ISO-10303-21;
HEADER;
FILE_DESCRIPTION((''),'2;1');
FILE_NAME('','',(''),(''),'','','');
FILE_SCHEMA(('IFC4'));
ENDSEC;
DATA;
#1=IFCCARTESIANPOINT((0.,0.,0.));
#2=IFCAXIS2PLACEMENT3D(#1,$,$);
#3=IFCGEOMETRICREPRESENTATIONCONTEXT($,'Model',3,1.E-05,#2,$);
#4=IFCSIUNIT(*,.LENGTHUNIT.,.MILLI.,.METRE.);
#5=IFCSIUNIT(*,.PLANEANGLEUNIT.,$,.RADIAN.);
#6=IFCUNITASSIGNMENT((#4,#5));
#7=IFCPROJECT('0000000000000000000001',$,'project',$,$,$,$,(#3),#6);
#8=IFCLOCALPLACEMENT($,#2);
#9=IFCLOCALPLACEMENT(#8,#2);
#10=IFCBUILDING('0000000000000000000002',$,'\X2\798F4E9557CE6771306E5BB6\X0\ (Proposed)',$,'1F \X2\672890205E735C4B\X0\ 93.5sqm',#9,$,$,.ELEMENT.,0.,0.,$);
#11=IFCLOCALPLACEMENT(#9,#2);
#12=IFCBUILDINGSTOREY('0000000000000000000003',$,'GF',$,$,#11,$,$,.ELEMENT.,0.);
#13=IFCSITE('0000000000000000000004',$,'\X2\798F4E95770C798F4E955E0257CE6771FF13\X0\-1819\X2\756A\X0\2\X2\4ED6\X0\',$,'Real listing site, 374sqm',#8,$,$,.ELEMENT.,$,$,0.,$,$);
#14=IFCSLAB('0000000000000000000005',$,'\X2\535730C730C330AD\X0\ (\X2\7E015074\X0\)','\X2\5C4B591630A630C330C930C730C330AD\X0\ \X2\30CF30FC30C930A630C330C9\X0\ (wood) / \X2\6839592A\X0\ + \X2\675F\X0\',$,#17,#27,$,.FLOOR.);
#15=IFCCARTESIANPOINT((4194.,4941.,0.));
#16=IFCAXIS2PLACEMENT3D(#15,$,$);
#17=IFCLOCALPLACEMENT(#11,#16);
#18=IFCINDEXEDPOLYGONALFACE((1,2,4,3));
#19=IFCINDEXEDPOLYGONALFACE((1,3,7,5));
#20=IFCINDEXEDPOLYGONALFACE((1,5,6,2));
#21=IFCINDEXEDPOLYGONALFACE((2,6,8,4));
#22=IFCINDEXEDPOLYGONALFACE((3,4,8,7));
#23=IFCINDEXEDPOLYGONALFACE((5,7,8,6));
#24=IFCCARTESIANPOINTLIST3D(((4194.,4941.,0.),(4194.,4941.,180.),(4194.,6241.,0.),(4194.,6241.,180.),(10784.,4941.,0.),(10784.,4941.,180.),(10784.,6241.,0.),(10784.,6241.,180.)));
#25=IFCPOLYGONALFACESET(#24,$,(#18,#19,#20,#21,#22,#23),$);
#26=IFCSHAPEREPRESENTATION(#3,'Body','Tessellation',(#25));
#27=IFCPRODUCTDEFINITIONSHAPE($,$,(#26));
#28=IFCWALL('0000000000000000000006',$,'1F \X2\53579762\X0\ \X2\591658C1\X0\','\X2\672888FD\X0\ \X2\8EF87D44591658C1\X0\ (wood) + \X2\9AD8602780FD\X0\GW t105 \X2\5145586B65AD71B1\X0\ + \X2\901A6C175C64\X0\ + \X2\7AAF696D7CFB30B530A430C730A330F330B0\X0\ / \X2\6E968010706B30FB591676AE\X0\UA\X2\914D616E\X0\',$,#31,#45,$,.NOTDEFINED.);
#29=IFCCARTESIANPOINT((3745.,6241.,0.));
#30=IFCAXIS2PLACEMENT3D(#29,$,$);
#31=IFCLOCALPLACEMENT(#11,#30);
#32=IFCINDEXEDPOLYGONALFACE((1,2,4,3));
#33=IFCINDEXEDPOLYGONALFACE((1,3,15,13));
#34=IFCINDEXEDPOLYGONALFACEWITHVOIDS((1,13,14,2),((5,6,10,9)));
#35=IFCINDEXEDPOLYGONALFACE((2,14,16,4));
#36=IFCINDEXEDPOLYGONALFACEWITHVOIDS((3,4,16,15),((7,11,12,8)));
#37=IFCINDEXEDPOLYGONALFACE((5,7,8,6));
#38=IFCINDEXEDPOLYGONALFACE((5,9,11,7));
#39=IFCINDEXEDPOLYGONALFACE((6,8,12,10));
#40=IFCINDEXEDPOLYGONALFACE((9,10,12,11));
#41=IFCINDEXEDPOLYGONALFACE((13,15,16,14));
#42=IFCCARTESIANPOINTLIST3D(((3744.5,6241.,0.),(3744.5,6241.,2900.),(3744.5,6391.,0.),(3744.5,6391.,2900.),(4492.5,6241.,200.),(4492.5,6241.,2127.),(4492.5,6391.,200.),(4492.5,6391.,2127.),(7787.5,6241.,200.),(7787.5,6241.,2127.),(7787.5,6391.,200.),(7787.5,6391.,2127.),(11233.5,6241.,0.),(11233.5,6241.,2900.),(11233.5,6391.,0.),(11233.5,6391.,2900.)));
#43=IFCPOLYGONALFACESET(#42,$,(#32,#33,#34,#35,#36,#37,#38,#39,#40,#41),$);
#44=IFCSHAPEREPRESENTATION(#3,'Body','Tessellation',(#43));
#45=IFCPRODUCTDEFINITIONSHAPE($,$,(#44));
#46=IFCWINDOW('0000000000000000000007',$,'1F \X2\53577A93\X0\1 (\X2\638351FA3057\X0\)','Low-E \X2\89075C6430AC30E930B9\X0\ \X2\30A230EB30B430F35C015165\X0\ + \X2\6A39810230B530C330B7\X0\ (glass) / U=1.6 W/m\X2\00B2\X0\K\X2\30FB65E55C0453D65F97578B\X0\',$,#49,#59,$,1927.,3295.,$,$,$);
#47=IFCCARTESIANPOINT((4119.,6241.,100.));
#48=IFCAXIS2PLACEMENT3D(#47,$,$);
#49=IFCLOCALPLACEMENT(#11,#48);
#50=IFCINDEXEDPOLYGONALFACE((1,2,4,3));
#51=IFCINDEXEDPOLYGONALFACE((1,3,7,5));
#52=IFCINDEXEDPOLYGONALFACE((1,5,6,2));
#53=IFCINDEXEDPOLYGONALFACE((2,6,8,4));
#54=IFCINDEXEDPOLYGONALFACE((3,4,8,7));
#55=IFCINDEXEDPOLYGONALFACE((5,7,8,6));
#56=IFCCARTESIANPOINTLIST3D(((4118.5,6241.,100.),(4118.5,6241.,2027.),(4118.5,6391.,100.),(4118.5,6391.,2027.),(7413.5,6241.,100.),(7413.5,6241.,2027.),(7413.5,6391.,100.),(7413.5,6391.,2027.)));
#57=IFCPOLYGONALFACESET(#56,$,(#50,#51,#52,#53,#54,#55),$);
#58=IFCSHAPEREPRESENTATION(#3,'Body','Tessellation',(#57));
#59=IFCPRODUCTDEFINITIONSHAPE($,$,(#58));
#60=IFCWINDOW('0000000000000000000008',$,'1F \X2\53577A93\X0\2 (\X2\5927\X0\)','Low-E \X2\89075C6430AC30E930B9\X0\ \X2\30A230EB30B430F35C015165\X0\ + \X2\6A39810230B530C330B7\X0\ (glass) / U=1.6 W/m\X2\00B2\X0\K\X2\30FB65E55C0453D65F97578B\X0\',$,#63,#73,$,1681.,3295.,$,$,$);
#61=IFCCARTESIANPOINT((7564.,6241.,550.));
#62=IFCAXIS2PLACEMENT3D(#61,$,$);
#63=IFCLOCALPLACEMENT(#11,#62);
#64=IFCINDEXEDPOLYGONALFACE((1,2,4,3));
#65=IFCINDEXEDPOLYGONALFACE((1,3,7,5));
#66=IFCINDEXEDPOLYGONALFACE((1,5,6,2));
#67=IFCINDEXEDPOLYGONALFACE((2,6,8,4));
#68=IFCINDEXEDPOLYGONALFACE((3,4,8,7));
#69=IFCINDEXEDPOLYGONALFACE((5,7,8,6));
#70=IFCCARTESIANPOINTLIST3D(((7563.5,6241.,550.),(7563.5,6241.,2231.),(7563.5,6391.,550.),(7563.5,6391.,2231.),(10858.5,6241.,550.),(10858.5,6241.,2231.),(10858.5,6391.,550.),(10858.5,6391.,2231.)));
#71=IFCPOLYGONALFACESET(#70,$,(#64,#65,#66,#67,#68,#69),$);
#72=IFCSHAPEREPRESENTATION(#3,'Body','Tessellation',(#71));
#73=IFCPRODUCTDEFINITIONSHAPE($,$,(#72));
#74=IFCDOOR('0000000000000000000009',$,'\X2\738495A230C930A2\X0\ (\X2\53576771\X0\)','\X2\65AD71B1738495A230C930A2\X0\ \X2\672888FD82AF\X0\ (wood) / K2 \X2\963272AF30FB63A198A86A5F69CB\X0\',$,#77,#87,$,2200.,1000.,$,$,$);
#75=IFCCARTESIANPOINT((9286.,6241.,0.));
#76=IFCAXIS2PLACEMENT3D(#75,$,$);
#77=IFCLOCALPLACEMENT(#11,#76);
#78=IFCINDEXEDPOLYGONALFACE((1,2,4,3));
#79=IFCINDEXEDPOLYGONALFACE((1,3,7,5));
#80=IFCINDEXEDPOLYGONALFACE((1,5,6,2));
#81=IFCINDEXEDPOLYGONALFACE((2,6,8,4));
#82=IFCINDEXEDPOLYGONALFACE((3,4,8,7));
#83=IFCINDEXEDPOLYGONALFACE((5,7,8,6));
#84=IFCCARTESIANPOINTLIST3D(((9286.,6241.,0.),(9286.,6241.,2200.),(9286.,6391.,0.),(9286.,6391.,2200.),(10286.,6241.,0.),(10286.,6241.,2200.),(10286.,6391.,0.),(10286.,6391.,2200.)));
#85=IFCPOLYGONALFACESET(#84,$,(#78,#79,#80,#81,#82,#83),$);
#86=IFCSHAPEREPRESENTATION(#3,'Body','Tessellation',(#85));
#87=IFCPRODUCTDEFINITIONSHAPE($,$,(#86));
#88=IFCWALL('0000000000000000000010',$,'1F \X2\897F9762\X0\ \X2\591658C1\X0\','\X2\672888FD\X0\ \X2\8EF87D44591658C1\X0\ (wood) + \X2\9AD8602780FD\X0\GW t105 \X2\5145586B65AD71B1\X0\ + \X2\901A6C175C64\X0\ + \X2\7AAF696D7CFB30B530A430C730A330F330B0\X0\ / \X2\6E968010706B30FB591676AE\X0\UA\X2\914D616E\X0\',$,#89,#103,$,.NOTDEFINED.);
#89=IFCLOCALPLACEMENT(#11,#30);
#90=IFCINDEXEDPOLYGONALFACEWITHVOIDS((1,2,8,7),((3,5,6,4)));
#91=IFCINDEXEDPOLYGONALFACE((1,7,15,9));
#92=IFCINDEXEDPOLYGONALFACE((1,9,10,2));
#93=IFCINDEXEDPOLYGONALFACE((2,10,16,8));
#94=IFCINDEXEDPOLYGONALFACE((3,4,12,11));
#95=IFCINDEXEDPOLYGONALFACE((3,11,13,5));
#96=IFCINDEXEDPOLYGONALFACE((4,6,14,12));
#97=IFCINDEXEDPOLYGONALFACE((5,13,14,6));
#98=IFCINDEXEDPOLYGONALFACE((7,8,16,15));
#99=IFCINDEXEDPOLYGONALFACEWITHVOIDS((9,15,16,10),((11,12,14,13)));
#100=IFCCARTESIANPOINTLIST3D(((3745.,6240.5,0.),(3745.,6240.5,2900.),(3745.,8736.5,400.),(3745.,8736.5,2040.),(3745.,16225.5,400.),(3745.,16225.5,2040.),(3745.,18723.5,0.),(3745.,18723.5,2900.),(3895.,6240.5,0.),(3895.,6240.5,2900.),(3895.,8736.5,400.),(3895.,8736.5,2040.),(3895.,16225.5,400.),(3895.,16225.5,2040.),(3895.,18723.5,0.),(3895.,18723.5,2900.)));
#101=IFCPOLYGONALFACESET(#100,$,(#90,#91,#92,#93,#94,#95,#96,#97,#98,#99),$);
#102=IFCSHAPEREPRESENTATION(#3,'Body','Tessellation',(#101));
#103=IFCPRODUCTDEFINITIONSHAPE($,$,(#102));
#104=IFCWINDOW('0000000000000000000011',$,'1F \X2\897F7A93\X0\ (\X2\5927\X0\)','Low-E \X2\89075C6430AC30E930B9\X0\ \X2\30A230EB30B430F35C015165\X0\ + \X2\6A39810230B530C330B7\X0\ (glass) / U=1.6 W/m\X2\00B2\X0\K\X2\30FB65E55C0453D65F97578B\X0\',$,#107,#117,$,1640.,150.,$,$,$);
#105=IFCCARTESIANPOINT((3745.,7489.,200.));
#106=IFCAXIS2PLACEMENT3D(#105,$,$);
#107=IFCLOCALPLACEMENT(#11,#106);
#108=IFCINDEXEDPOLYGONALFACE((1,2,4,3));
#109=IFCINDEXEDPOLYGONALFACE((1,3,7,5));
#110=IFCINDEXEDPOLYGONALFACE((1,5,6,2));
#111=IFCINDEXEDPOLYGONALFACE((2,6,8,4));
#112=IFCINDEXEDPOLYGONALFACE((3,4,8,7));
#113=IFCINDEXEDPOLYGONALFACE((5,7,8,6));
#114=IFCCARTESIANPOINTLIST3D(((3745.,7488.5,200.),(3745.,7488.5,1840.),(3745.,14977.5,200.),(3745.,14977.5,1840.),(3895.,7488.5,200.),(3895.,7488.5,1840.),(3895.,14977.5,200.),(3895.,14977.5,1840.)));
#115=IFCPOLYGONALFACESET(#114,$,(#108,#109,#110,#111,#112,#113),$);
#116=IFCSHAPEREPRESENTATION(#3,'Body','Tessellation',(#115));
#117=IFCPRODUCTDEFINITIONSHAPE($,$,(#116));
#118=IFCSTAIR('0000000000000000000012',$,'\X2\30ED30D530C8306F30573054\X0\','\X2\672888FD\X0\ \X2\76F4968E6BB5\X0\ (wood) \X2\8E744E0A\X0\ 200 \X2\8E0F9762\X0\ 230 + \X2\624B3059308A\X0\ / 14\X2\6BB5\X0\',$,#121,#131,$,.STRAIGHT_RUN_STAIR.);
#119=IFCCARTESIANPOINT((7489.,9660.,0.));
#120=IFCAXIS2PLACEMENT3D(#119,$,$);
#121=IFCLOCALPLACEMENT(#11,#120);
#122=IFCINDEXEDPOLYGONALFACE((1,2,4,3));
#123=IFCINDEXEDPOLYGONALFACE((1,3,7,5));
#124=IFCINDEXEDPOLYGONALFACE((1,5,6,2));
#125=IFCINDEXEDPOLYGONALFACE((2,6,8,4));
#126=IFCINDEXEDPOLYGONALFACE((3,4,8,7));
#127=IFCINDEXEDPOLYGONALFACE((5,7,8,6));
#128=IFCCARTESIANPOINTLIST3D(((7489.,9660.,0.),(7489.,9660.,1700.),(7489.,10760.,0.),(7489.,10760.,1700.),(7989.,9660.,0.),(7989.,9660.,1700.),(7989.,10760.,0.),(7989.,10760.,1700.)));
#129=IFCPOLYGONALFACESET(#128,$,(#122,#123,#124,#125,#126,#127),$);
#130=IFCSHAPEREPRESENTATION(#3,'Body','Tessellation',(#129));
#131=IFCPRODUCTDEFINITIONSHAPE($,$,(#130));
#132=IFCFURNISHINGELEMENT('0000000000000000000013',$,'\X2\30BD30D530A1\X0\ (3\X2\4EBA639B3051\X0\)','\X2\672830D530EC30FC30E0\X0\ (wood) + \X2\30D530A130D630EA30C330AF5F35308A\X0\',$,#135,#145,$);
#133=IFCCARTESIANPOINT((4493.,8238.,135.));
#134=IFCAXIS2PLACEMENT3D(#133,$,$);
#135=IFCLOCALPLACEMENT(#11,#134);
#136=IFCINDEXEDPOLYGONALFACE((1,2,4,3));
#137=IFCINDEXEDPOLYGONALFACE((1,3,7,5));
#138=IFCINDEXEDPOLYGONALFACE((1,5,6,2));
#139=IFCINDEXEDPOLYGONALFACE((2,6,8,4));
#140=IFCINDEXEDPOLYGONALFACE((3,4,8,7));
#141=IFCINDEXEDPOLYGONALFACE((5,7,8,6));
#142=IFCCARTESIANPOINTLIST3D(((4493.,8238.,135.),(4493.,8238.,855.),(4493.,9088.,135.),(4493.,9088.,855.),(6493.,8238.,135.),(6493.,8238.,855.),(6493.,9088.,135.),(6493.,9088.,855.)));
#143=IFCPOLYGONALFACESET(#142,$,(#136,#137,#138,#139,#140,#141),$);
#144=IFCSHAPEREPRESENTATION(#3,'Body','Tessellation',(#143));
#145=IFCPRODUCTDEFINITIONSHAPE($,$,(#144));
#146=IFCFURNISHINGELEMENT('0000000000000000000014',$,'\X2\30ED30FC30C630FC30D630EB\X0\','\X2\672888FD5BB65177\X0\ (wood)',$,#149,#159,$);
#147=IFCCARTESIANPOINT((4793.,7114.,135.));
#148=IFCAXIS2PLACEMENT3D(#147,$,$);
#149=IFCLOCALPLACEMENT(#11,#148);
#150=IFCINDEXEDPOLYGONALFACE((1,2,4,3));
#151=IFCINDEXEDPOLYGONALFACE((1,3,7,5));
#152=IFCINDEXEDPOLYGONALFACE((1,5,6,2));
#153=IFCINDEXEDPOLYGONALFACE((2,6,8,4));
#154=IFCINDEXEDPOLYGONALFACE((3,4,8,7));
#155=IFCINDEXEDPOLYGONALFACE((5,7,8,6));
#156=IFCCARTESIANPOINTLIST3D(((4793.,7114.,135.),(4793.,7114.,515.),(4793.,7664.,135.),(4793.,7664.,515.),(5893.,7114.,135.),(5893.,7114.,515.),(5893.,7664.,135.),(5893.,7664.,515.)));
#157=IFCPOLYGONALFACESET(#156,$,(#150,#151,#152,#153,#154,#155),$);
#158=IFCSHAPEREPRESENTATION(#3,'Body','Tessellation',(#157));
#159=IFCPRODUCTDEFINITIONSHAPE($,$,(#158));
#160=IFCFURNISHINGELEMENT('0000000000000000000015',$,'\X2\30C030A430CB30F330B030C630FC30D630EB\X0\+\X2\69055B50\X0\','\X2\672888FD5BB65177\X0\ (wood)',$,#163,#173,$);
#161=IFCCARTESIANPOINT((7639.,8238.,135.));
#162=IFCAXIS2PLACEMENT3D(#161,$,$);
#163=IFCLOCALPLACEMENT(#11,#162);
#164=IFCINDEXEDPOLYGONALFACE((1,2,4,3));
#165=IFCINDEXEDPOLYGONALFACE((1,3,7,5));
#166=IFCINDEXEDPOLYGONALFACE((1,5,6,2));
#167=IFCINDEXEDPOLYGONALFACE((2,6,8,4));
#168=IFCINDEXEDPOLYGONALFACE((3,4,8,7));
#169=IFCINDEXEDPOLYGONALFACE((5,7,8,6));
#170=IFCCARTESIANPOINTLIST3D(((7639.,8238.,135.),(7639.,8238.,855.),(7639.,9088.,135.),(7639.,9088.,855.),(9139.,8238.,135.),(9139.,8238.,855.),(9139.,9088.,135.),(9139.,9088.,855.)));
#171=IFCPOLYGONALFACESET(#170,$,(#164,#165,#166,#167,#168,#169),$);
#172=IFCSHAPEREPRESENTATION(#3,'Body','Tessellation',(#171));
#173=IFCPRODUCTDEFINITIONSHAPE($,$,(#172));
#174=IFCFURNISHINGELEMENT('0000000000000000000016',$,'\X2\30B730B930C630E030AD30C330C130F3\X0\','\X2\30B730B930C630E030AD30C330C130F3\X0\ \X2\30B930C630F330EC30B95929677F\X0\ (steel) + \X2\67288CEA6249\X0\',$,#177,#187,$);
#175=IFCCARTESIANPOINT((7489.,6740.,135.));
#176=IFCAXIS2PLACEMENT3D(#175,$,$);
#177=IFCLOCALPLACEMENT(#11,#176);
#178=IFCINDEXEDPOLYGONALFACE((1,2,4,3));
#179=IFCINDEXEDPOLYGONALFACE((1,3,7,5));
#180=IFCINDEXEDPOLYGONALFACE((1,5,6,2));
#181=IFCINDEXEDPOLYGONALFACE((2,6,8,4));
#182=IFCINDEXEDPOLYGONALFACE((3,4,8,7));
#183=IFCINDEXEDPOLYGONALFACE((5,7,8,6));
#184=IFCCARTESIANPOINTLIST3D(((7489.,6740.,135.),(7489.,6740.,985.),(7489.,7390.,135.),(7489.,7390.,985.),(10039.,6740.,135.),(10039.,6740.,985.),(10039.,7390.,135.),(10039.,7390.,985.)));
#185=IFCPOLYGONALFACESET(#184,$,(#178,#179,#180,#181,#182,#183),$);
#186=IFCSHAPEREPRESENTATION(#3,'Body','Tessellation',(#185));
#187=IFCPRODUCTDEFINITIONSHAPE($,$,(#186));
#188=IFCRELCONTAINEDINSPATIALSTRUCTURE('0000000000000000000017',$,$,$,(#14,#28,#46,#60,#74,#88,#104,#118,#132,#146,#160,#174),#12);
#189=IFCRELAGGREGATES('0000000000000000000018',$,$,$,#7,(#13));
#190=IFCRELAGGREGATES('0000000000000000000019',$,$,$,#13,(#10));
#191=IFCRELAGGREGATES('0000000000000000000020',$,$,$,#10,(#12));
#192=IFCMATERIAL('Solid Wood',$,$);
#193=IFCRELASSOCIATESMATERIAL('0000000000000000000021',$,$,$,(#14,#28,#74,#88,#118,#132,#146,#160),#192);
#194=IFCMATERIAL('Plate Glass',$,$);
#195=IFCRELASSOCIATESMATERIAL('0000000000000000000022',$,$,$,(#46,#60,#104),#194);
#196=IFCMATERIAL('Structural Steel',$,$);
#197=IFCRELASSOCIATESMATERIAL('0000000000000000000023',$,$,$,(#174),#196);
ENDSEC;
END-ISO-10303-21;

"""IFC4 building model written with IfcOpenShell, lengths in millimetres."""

from ifc_helpers import new_model, si_unit, frame, frame_2d, origin, place, context, project, spatial, rectangle, extrude, material, element, fill, save


model = new_model("IFC4")

# Units and contexts
model_context = context("Model", 3, precision=1e-05, world=origin())
ifc_project = project(units=[si_unit("LENGTHUNIT", "METRE", prefix="MILLI"), si_unit("PLANEANGLEUNIT", "RADIAN")], contexts=[model_context])

# Site, building, storey
site_placement = place(None, origin())
site = spatial("IfcSite", under=ifc_project, at=site_placement, Name="福井県福井市城東３-1819番2他", ObjectType="Real listing site, 374sqm", CompositionType="ELEMENT", RefElevation=0.0)
building_placement = place(site_placement, origin())
building = spatial("IfcBuilding", under=site, at=building_placement, Name="福井城東の家 (Proposed)", ObjectType="1F 木造平屋 93.5sqm", CompositionType="ELEMENT", ElevationOfRefHeight=0.0, ElevationOfTerrain=0.0)
storey_placement = place(building_placement, origin())
storey = spatial("IfcBuildingStorey", under=building, at=storey_placement, Name="GF", CompositionType="ELEMENT", Elevation=0.0)

# Slab
ifc_material_1 = material(Name="Solid Wood")
slab_1_placement = place(storey_placement, frame((4194.0, 4941.0, 0.0)))
element("IfcSlab", 1, at=slab_1_placement, inside=storey, material=ifc_material_1, Name="南デッキ (縁側)", Description="屋外ウッドデッキ ハードウッド (wood) / 根太 + 束", PredefinedType="FLOOR", context=model_context, shape_type="SweptSolid", body=[
    extrude(rectangle(XDim=6590.0, YDim=1300.0, at=frame_2d((3295.0, 650.0))), frame((4194.0, 4941.0, 0.0)), (0.0, 0.0, 1.0), 180.0),
])

# Wall, openings, windows, door
wall_1_placement = place(storey_placement, frame((3745.0, 6241.0, 0.0)))
wall_1 = element("IfcWall", 2, at=wall_1_placement, inside=storey, material=ifc_material_1, Name="1F 南面 外壁", Description="木製 軸組外壁 (wood) + 高性能GW t105 充填断熱 + 通気層 + 窯業系サイディング / 準耐火・外皮UA配慮", PredefinedType="NOTDEFINED", context=model_context, shape_type="SweptSolid", body=[
    extrude(rectangle(XDim=7489.0, YDim=150.0, at=frame_2d((3744.0, 75.0))), frame((3745.0, 6241.0, 0.0)), (0.0, 0.0, 1.0), 2900.0),
])
opening_1_placement = place(storey_placement, frame((4119.0, 6241.0, 100.0)))
opening_1 = element("IfcOpeningElement", 3, at=opening_1_placement, cuts=wall_1, PredefinedType="NOTDEFINED", context=model_context, shape_type="SweptSolid", body=[
    extrude(rectangle(XDim=3295.0, YDim=150.0, at=frame_2d((1647.0, 75.0))), frame((4119.0, 6241.0, 100.0)), (0.0, 0.0, 1.0), 1927.0),
])
opening_2_placement = place(storey_placement, frame((7564.0, 6241.0, 550.0)))
opening_2 = element("IfcOpeningElement", 4, at=opening_2_placement, cuts=wall_1, PredefinedType="NOTDEFINED", context=model_context, shape_type="SweptSolid", body=[
    extrude(rectangle(XDim=3295.0, YDim=150.0, at=frame_2d((1647.0, 75.0))), frame((7564.0, 6241.0, 550.0)), (0.0, 0.0, 1.0), 1681.0),
])
opening_3_placement = place(storey_placement, frame((9286.0, 6241.0, 0.0)))
opening_3 = element("IfcOpeningElement", 5, at=opening_3_placement, cuts=wall_1, PredefinedType="NOTDEFINED", context=model_context, shape_type="SweptSolid", body=[
    extrude(rectangle(XDim=1000.0, YDim=150.0, at=frame_2d((500.0, 75.0))), frame((9286.0, 6241.0, 0.0)), (0.0, 0.0, 1.0), 2200.0),
])
ifc_material_2 = material(Name="Plate Glass")
window_1_placement = place(storey_placement, frame((4119.0, 6241.0, 100.0)))
window_1 = element("IfcWindow", 6, at=window_1_placement, inside=storey, material=ifc_material_2, Name="1F 南窓1 (掃出し)", Description="Low-E 複層ガラス アルゴン封入 + 樹脂サッシ (glass) / U=1.6 W/m²K・日射取得型", OverallHeight=1927.0, OverallWidth=3295.0, context=model_context, shape_type="SweptSolid", body=[
    extrude(rectangle(XDim=3295.0, YDim=150.0, at=frame_2d((1647.0, 75.0))), frame((4119.0, 6241.0, 100.0)), (0.0, 0.0, 1.0), 1927.0),
])
fill(opening_1, window_1)
window_2_placement = place(storey_placement, frame((7564.0, 6241.0, 550.0)))
window_2 = element("IfcWindow", 7, at=window_2_placement, inside=storey, material=ifc_material_2, Name="1F 南窓2 (大)", Description="Low-E 複層ガラス アルゴン封入 + 樹脂サッシ (glass) / U=1.6 W/m²K・日射取得型", OverallHeight=1681.0, OverallWidth=3295.0, context=model_context, shape_type="SweptSolid", body=[
    extrude(rectangle(XDim=3295.0, YDim=150.0, at=frame_2d((1647.0, 75.0))), frame((7564.0, 6241.0, 550.0)), (0.0, 0.0, 1.0), 1681.0),
])
fill(opening_2, window_2)
door_placement = place(storey_placement, frame((9286.0, 6241.0, 0.0)))
door = element("IfcDoor", 8, at=door_placement, inside=storey, material=ifc_material_1, Name="玄関ドア (南東)", Description="断熱玄関ドア 木製芯 (wood) / K2 防犯・採風機構", OverallHeight=2200.0, OverallWidth=1000.0, context=model_context, shape_type="SweptSolid", body=[
    extrude(rectangle(XDim=1000.0, YDim=150.0, at=frame_2d((500.0, 75.0))), frame((9286.0, 6241.0, 0.0)), (0.0, 0.0, 1.0), 2200.0),
])
fill(opening_3, door)

# Wall, opening, window
wall_2_placement = place(storey_placement, frame((3745.0, 6241.0, 0.0)))
wall_2 = element("IfcWall", 9, at=wall_2_placement, inside=storey, material=ifc_material_1, Name="1F 西面 外壁", Description="木製 軸組外壁 (wood) + 高性能GW t105 充填断熱 + 通気層 + 窯業系サイディング / 準耐火・外皮UA配慮", PredefinedType="NOTDEFINED", context=model_context, shape_type="SweptSolid", body=[
    extrude(rectangle(XDim=150.0, YDim=12483.0, at=frame_2d((75.0, 6241.0))), frame((3745.0, 6241.0, 0.0)), (0.0, 0.0, 1.0), 2900.0),
])
opening_4_placement = place(storey_placement, frame((3745.0, 7489.0, 200.0)))
opening_4 = element("IfcOpeningElement", 10, at=opening_4_placement, cuts=wall_2, PredefinedType="NOTDEFINED", context=model_context, shape_type="SweptSolid", body=[
    extrude(rectangle(XDim=150.0, YDim=7489.0, at=frame_2d((75.0, 3744.0))), frame((3745.0, 7489.0, 200.0)), (0.0, 0.0, 1.0), 1640.0),
])
window_3_placement = place(storey_placement, frame((3745.0, 7489.0, 200.0)))
window_3 = element("IfcWindow", 11, at=window_3_placement, inside=storey, material=ifc_material_2, Name="1F 西窓 (大)", Description="Low-E 複層ガラス アルゴン封入 + 樹脂サッシ (glass) / U=1.6 W/m²K・日射取得型", OverallHeight=1640.0, OverallWidth=150.0, context=model_context, shape_type="SweptSolid", body=[
    extrude(rectangle(XDim=150.0, YDim=7489.0, at=frame_2d((75.0, 3744.0))), frame((3745.0, 7489.0, 200.0)), (0.0, 0.0, 1.0), 1640.0),
])
fill(opening_4, window_3)

# Stair
stair_placement = place(storey_placement, frame((7489.0, 9660.0, 0.0)))
element("IfcStair", 12, at=stair_placement, inside=storey, material=ifc_material_1, Name="ロフトはしご", Description="木製 直階段 (wood) 蹴上 200 踏面 230 + 手すり / 14段", PredefinedType="STRAIGHT_RUN_STAIR", context=model_context, shape_type="SweptSolid", body=[
    extrude(rectangle(XDim=500.0, YDim=1100.0, at=frame_2d((250.0, 550.0))), frame((7489.0, 9660.0, 0.0)), (0.0, 0.0, 1.0), 1700.0),
])

# Shared definitions
ifc_material_3 = material(Name="Structural Steel")

# Furnishing elements
furnishing_1_placement = place(storey_placement, frame((4493.0, 8238.0, 135.0)))
element("IfcFurnishingElement", 13, at=furnishing_1_placement, inside=storey, material=ifc_material_1, Name="ソファ (3人掛け)", Description="木フレーム (wood) + ファブリック張り", context=model_context, shape_type="SweptSolid", body=[
    extrude(rectangle(XDim=2000.0, YDim=850.0, at=frame_2d((1000.0, 425.0))), frame((4493.0, 8238.0, 135.0)), (0.0, 0.0, 1.0), 720.0),
])
furnishing_2_placement = place(storey_placement, frame((4793.0, 7114.0, 135.0)))
element("IfcFurnishingElement", 14, at=furnishing_2_placement, inside=storey, material=ifc_material_1, Name="ローテーブル", Description="木製家具 (wood)", context=model_context, shape_type="SweptSolid", body=[
    extrude(rectangle(XDim=1100.0, YDim=550.0, at=frame_2d((550.0, 275.0))), frame((4793.0, 7114.0, 135.0)), (0.0, 0.0, 1.0), 380.0),
])
furnishing_3_placement = place(storey_placement, frame((7639.0, 8238.0, 135.0)))
element("IfcFurnishingElement", 15, at=furnishing_3_placement, inside=storey, material=ifc_material_1, Name="ダイニングテーブル+椅子", Description="木製家具 (wood)", context=model_context, shape_type="SweptSolid", body=[
    extrude(rectangle(XDim=1500.0, YDim=850.0, at=frame_2d((750.0, 425.0))), frame((7639.0, 8238.0, 135.0)), (0.0, 0.0, 1.0), 720.0),
])
furnishing_4_placement = place(storey_placement, frame((7489.0, 6740.0, 135.0)))
element("IfcFurnishingElement", 16, at=furnishing_4_placement, inside=storey, material=ifc_material_3, Name="システムキッチン", Description="システムキッチン ステンレス天板 (steel) + 木質扉", context=model_context, shape_type="SweptSolid", body=[
    extrude(rectangle(XDim=2550.0, YDim=650.0, at=frame_2d((1275.0, 325.0))), frame((7489.0, 6740.0, 135.0)), (0.0, 0.0, 1.0), 850.0),
])

save(model, "model.ifc")
